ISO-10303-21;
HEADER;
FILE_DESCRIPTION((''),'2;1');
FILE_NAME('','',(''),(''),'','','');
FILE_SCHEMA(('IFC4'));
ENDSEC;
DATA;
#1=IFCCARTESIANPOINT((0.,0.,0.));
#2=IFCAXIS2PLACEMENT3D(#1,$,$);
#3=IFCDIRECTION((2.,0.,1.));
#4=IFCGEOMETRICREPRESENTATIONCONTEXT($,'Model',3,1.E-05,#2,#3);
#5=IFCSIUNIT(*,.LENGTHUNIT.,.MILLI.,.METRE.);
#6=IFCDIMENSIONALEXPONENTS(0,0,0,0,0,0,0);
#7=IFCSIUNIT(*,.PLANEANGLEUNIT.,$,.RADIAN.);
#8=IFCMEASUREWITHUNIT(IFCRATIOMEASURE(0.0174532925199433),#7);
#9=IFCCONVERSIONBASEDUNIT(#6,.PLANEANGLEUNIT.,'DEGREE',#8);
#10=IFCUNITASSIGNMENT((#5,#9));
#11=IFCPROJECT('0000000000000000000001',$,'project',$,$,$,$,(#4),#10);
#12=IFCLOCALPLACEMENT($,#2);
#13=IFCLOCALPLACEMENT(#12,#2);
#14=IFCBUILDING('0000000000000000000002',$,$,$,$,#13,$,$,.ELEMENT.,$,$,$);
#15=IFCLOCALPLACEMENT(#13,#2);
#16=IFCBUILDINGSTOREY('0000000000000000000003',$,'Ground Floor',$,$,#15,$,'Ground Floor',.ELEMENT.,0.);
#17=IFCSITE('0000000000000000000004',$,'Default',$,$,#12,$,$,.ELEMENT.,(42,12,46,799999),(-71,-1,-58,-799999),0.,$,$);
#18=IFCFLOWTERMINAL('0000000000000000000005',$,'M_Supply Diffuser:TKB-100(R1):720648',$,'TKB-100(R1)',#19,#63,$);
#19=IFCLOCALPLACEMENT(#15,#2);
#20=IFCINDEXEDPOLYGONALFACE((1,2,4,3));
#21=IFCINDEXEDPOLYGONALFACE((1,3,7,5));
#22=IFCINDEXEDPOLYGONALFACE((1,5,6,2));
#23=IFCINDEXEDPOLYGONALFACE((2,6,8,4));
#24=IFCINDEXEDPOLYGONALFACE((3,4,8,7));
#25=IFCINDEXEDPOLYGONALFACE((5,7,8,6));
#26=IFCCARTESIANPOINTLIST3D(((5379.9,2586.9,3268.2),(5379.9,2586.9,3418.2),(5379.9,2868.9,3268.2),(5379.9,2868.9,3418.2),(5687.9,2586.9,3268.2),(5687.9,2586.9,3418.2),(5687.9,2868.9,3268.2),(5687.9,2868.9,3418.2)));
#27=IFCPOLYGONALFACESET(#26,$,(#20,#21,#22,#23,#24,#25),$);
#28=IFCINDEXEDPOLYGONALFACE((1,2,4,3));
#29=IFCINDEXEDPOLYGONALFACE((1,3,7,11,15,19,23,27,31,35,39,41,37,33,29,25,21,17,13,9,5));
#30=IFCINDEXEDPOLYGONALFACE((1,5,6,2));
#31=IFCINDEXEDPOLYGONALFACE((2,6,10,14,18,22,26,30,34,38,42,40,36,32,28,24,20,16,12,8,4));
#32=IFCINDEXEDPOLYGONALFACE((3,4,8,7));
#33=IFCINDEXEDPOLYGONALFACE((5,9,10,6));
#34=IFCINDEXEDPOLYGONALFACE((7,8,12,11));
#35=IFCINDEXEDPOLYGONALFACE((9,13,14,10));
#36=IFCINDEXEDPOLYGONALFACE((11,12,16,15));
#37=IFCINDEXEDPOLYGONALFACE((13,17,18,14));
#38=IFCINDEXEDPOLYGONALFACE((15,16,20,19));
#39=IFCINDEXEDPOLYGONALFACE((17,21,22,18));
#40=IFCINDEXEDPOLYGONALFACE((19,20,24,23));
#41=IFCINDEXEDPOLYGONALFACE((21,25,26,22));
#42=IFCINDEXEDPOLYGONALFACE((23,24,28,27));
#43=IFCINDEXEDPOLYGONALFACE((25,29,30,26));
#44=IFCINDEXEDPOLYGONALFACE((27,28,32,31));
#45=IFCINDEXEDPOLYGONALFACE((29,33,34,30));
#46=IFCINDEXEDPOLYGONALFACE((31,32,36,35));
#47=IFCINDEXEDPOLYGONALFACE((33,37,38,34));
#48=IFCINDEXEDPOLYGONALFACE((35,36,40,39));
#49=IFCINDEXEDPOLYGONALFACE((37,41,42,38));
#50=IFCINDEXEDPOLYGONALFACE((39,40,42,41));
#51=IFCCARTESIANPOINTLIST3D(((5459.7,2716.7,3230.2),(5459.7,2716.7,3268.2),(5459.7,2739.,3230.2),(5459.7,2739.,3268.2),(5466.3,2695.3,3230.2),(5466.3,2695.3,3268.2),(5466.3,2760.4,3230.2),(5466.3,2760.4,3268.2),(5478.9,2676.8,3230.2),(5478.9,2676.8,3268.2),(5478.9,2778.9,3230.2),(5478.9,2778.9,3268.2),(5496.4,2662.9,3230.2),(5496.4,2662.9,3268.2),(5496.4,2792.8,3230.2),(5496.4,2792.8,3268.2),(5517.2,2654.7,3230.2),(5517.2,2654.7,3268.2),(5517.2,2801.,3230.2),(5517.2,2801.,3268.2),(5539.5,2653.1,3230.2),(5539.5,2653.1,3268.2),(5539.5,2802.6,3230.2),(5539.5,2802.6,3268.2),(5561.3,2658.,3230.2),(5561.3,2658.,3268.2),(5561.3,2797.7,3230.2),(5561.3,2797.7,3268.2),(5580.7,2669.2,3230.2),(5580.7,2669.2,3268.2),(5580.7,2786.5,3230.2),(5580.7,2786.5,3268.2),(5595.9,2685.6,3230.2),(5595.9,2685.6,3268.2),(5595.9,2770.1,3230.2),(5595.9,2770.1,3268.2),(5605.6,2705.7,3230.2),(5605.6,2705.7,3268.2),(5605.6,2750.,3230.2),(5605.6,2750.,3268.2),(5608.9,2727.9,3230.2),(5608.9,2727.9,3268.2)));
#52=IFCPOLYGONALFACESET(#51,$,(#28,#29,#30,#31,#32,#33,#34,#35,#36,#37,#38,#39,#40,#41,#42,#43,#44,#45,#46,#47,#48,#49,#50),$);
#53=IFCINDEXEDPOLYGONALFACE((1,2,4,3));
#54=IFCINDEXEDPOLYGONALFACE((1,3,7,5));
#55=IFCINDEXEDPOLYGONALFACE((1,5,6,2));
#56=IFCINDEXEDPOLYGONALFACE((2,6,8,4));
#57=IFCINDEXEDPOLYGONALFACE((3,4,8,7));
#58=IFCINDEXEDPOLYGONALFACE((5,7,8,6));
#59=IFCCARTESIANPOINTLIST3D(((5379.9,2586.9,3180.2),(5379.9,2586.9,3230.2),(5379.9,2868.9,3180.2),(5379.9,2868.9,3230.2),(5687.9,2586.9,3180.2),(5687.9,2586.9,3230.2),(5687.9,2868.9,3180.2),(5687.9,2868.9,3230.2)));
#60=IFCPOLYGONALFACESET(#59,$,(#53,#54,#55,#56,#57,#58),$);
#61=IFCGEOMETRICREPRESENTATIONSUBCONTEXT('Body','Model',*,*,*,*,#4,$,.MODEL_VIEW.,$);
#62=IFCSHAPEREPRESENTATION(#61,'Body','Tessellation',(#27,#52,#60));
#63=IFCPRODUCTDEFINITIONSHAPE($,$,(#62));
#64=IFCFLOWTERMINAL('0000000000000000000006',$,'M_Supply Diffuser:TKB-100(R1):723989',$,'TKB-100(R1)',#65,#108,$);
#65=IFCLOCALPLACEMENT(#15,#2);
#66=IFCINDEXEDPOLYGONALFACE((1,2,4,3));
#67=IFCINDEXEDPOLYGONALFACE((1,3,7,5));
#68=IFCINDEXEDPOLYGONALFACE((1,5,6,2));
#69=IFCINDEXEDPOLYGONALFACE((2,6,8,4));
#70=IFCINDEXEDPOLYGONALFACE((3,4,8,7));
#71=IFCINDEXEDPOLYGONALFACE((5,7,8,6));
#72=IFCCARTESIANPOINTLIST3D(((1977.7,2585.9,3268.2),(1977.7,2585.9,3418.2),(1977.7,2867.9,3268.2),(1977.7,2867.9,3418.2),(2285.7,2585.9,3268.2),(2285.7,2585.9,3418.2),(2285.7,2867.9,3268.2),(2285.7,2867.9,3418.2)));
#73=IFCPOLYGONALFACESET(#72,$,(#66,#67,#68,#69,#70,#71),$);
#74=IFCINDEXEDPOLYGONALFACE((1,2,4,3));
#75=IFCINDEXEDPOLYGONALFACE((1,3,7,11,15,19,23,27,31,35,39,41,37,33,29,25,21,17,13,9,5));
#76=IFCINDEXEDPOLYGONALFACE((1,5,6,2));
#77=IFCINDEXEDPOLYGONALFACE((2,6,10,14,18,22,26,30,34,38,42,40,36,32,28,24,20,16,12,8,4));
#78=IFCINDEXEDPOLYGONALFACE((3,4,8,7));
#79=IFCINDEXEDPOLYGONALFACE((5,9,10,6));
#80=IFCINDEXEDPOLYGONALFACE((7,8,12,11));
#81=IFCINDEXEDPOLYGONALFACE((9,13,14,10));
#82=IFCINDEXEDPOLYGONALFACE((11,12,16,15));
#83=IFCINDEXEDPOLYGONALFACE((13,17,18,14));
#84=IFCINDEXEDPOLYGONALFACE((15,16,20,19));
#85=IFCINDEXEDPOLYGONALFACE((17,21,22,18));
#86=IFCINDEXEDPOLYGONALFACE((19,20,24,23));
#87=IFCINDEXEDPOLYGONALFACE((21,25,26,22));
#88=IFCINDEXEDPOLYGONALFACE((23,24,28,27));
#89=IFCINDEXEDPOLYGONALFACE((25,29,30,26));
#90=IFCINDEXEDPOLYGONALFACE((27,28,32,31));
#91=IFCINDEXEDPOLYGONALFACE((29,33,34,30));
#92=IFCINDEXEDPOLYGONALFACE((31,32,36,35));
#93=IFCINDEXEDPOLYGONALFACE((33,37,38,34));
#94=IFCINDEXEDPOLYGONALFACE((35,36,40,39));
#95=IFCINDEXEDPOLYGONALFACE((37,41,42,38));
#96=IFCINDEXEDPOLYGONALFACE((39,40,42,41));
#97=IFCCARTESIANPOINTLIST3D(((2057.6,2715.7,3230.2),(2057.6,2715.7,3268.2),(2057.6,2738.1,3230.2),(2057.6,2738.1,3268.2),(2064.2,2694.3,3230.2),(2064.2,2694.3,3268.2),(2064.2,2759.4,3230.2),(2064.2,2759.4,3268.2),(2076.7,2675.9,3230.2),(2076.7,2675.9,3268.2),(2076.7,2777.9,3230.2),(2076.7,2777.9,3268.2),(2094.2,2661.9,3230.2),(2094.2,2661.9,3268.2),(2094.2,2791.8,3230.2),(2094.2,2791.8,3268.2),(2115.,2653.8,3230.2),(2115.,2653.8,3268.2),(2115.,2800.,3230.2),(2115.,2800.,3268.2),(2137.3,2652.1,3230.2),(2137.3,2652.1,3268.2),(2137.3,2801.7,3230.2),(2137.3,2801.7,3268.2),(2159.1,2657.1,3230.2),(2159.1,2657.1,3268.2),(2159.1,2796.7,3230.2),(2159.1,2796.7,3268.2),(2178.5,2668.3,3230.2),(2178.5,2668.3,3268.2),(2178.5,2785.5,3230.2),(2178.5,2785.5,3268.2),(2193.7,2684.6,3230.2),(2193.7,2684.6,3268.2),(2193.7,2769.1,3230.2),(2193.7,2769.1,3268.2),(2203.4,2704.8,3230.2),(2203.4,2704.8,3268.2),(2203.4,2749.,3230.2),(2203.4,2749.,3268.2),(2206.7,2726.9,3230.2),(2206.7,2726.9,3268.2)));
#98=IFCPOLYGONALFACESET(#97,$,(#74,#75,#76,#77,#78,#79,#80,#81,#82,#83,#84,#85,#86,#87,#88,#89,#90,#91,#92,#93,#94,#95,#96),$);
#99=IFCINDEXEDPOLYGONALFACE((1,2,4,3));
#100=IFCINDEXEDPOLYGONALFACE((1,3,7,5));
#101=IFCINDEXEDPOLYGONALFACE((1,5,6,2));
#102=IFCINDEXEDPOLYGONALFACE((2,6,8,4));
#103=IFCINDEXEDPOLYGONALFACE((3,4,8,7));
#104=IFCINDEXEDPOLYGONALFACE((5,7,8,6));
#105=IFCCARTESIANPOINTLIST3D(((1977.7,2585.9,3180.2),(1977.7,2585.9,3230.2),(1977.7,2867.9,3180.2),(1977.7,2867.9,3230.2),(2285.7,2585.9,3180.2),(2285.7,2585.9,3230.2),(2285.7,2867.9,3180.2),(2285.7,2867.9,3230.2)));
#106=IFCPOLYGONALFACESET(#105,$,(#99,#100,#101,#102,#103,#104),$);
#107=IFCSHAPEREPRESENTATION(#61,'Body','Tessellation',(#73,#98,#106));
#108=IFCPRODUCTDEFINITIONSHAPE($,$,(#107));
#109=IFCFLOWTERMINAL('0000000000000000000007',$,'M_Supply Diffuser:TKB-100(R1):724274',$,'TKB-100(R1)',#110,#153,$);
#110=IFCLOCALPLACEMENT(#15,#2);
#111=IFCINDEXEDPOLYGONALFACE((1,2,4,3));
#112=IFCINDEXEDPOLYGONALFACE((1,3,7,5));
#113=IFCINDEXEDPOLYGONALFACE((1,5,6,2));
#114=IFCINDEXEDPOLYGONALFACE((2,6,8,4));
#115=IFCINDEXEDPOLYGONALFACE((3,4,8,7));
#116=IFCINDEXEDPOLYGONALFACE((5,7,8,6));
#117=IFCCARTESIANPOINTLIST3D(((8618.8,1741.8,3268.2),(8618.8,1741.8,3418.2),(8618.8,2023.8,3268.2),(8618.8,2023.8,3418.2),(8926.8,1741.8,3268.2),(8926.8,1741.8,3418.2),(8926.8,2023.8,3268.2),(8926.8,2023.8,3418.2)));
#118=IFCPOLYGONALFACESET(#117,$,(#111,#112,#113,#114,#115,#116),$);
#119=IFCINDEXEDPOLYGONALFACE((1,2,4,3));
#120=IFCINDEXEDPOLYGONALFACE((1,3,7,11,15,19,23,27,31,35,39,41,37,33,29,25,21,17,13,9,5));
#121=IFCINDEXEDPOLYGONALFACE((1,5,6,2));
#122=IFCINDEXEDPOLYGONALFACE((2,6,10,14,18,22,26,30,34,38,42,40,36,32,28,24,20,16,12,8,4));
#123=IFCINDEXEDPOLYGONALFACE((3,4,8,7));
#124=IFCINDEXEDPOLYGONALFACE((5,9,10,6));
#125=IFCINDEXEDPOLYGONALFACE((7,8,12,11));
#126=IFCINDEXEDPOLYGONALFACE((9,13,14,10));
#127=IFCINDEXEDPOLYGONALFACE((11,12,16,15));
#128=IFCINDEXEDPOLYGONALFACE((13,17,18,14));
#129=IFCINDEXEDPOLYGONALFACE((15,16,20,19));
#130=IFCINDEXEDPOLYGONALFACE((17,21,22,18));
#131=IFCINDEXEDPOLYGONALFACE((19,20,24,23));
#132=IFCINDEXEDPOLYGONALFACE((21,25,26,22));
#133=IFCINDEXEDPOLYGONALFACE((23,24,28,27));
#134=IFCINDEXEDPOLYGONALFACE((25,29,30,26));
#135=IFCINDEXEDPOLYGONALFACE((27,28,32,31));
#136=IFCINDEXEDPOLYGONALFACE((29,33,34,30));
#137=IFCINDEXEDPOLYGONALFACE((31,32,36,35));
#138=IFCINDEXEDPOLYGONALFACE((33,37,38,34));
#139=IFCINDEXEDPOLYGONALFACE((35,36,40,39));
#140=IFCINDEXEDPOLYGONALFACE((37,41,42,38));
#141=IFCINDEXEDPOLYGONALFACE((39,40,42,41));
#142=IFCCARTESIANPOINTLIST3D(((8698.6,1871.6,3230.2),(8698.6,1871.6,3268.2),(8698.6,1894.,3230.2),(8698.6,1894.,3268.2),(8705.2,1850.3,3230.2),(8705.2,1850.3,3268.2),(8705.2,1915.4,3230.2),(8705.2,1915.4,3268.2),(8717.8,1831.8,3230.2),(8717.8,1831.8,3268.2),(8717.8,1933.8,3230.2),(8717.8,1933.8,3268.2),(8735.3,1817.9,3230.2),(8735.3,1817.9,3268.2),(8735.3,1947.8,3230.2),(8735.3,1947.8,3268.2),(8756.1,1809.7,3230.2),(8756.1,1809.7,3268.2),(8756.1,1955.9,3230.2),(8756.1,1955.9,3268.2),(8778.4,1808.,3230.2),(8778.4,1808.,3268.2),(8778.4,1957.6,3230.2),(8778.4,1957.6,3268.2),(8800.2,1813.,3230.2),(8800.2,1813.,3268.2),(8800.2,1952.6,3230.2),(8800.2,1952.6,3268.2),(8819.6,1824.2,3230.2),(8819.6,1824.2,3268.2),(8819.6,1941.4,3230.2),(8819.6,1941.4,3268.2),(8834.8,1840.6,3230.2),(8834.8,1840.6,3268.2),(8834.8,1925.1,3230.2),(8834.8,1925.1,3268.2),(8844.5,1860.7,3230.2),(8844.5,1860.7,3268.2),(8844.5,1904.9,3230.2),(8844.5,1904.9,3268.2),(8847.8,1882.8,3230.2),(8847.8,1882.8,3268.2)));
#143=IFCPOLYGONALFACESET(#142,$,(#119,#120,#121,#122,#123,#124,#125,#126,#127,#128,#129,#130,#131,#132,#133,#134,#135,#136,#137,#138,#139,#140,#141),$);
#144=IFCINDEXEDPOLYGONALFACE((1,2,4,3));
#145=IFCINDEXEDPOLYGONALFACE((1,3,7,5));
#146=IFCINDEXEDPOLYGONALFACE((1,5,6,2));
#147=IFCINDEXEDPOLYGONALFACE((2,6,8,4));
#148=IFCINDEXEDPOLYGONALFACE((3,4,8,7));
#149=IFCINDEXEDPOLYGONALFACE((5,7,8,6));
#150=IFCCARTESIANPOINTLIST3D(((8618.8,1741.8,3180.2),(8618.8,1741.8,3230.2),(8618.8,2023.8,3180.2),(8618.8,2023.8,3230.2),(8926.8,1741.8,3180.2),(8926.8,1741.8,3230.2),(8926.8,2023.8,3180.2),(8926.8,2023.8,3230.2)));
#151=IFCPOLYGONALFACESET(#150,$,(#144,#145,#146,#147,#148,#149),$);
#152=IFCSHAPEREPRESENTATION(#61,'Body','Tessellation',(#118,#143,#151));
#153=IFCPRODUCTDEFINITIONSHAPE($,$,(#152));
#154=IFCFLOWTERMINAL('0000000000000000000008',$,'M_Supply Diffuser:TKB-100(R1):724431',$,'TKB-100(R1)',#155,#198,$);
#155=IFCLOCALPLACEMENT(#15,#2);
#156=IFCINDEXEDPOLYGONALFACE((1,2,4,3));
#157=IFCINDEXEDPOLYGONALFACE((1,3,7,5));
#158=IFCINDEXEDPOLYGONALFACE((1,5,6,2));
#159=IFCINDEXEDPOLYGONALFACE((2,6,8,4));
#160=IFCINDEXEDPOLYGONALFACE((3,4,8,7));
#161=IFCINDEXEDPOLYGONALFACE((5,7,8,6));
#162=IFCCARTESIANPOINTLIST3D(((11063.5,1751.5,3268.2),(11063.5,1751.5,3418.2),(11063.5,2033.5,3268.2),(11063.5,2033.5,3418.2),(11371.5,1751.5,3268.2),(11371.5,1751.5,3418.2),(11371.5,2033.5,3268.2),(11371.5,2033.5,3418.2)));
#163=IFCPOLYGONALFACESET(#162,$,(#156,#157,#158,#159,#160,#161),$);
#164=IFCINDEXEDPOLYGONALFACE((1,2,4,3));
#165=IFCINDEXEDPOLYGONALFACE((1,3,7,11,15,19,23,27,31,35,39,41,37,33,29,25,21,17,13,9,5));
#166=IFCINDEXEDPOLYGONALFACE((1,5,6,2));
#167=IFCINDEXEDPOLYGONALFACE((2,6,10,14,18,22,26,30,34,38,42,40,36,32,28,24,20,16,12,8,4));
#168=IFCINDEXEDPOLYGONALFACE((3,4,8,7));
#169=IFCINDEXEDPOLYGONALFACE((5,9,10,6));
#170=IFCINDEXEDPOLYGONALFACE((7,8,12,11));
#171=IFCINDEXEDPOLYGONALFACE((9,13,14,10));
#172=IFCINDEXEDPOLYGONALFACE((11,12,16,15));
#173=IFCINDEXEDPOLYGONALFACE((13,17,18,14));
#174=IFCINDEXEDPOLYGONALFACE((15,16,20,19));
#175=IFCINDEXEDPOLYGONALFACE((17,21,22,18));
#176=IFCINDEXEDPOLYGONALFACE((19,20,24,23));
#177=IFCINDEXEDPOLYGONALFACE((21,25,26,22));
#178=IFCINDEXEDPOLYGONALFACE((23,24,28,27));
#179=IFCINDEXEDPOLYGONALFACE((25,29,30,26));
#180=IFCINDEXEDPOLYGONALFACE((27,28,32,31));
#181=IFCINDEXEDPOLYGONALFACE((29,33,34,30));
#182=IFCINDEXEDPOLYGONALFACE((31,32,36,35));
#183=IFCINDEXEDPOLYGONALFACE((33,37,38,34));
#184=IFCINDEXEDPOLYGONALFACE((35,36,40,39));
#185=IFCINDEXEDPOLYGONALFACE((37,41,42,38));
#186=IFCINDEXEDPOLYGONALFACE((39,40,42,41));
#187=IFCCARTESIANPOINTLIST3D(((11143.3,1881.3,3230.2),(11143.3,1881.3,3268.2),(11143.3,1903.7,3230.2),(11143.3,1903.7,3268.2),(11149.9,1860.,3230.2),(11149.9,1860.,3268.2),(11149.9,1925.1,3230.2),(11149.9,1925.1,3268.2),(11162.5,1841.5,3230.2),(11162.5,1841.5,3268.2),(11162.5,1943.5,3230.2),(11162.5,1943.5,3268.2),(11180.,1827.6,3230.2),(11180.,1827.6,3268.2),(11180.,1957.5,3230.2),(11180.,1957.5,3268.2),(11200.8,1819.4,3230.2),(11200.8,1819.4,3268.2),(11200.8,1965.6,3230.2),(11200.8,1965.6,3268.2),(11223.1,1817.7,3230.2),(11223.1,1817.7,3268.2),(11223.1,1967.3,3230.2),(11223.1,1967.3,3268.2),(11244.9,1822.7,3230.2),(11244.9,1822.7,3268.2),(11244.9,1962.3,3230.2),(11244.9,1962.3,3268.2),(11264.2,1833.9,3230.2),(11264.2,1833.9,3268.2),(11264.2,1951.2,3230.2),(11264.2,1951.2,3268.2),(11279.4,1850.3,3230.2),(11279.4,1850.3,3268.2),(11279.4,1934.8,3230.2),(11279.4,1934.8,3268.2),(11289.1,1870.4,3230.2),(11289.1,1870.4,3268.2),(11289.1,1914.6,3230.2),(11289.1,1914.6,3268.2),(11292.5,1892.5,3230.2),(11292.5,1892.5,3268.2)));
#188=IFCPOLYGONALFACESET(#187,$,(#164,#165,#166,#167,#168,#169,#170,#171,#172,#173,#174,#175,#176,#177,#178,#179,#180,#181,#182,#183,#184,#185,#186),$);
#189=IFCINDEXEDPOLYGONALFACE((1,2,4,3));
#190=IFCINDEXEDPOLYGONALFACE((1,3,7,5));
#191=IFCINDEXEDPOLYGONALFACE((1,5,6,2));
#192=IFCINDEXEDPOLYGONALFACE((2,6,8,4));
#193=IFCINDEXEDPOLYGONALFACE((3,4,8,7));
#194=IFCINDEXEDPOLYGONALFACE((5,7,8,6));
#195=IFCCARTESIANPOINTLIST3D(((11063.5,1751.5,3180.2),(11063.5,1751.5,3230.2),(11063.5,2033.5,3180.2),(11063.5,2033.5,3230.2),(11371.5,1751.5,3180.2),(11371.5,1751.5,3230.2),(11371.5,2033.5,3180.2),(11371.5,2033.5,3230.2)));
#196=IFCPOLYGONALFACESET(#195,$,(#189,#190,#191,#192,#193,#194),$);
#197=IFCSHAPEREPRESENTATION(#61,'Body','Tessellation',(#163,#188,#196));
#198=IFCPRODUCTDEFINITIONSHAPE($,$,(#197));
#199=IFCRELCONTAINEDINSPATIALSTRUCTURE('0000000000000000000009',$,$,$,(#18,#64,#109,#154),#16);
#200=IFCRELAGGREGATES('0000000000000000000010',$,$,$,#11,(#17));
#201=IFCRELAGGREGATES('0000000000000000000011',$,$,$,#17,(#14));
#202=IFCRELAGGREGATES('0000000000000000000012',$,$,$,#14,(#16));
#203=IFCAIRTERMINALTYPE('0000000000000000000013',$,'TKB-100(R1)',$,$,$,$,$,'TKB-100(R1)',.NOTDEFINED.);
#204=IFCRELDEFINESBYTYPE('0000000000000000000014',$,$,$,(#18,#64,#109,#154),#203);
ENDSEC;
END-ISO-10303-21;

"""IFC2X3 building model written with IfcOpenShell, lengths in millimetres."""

from ifc_helpers import new_model, entity, si_unit, converted_unit, direction, frame, frame_2d, origin, origin_2d_with_axis, place, context, subcontext, project, spatial, rectangle, circle, extrude, source, transform, mapped, type_object, type_shapes, element, save


model = new_model("IFC2X3")

# Units and contexts
model_context = context("Model", 3, precision=1e-05, world=origin(), true_north=direction((2.0, 0.0, 1.0)))
body_context = subcontext(model_context, "Body", "Model", "MODEL_VIEW")
ifc_project = project(units=[si_unit("LENGTHUNIT", "METRE", prefix="MILLI"), converted_unit("PLANEANGLEUNIT", "DEGREE", entity("IfcRatioMeasure", 0.0174532925199433), si_unit("PLANEANGLEUNIT", "RADIAN"), dimensions=[0, 0, 0, 0, 0, 0, 0])], contexts=[model_context])

# Site, building, storey
site_placement = place(None, origin())
site = spatial("IfcSite", under=ifc_project, at=site_placement, Name="Default", CompositionType="ELEMENT", RefLatitude=(42, 12, 46, 799999), RefLongitude=(-71, -1, -58, -799999), RefElevation=0.0)
building_placement = place(site_placement, origin())
building = spatial("IfcBuilding", under=site, at=building_placement, CompositionType="ELEMENT")
storey_placement = place(building_placement, origin())
storey = spatial("IfcBuildingStorey", under=building, at=storey_placement, Name="Ground Floor", LongName="Ground Floor", CompositionType="ELEMENT", Elevation=0.0)

# Flow terminals
air_terminal_type_1 = type_object("IfcAirTerminalType", Name="TKB-100(R1)", ElementType="TKB-100(R1)", PredefinedType="NOTDEFINED")
shared_shape_1 = source(origin(), body_context, "Body", "SweptSolid", [
    extrude(rectangle(XDim=308.0, YDim=282.0, at=origin_2d_with_axis()), frame((0.0, 0.0, 88.0), z_axis=(0.0, 0.0, 1.0), x_axis=(-1.0, 0.0, 0.0)), (0.0, 0.0, 1.0), 150.0),
    extrude(circle(Radius=75.0, at=frame_2d((0.0, 0.0), x_axis=(1.0, 0.0))), frame((0.0, 0.0, 50.0)), (0.0, 0.0, 1.0), 38.0),
    extrude(rectangle(XDim=282.0, YDim=308.0, at=origin_2d_with_axis()), frame((0.0, 0.0, 0.0), z_axis=(0.0, 0.0, 1.0), x_axis=(0.0, 1.0, 0.0)), (0.0, 0.0, 1.0), 50.0),
])
type_shapes(air_terminal_type_1, [shared_shape_1])
for number, where, name in (
    (1, (5533.9, 2727.9, 3180.2), "M_Supply Diffuser:TKB-100(R1):720648"),
    (2, (2131.7, 2726.9, 3180.2), "M_Supply Diffuser:TKB-100(R1):723989"),
    (3, (8772.8, 1882.8, 3180.2), "M_Supply Diffuser:TKB-100(R1):724274"),
    (4, (11217.5, 1892.5, 3180.2), "M_Supply Diffuser:TKB-100(R1):724431"),
):
    element("IfcFlowTerminal", number, at=place(storey_placement, frame(where)), inside=storey, type_object=air_terminal_type_1, Name=name, ObjectType="TKB-100(R1)", context=body_context, shape_type="MappedRepresentation", body=[
        mapped(shared_shape_1, transform((0.0, 0.0, 0.0), scale=1.0)),
    ])

save(model, "model.ifc")
